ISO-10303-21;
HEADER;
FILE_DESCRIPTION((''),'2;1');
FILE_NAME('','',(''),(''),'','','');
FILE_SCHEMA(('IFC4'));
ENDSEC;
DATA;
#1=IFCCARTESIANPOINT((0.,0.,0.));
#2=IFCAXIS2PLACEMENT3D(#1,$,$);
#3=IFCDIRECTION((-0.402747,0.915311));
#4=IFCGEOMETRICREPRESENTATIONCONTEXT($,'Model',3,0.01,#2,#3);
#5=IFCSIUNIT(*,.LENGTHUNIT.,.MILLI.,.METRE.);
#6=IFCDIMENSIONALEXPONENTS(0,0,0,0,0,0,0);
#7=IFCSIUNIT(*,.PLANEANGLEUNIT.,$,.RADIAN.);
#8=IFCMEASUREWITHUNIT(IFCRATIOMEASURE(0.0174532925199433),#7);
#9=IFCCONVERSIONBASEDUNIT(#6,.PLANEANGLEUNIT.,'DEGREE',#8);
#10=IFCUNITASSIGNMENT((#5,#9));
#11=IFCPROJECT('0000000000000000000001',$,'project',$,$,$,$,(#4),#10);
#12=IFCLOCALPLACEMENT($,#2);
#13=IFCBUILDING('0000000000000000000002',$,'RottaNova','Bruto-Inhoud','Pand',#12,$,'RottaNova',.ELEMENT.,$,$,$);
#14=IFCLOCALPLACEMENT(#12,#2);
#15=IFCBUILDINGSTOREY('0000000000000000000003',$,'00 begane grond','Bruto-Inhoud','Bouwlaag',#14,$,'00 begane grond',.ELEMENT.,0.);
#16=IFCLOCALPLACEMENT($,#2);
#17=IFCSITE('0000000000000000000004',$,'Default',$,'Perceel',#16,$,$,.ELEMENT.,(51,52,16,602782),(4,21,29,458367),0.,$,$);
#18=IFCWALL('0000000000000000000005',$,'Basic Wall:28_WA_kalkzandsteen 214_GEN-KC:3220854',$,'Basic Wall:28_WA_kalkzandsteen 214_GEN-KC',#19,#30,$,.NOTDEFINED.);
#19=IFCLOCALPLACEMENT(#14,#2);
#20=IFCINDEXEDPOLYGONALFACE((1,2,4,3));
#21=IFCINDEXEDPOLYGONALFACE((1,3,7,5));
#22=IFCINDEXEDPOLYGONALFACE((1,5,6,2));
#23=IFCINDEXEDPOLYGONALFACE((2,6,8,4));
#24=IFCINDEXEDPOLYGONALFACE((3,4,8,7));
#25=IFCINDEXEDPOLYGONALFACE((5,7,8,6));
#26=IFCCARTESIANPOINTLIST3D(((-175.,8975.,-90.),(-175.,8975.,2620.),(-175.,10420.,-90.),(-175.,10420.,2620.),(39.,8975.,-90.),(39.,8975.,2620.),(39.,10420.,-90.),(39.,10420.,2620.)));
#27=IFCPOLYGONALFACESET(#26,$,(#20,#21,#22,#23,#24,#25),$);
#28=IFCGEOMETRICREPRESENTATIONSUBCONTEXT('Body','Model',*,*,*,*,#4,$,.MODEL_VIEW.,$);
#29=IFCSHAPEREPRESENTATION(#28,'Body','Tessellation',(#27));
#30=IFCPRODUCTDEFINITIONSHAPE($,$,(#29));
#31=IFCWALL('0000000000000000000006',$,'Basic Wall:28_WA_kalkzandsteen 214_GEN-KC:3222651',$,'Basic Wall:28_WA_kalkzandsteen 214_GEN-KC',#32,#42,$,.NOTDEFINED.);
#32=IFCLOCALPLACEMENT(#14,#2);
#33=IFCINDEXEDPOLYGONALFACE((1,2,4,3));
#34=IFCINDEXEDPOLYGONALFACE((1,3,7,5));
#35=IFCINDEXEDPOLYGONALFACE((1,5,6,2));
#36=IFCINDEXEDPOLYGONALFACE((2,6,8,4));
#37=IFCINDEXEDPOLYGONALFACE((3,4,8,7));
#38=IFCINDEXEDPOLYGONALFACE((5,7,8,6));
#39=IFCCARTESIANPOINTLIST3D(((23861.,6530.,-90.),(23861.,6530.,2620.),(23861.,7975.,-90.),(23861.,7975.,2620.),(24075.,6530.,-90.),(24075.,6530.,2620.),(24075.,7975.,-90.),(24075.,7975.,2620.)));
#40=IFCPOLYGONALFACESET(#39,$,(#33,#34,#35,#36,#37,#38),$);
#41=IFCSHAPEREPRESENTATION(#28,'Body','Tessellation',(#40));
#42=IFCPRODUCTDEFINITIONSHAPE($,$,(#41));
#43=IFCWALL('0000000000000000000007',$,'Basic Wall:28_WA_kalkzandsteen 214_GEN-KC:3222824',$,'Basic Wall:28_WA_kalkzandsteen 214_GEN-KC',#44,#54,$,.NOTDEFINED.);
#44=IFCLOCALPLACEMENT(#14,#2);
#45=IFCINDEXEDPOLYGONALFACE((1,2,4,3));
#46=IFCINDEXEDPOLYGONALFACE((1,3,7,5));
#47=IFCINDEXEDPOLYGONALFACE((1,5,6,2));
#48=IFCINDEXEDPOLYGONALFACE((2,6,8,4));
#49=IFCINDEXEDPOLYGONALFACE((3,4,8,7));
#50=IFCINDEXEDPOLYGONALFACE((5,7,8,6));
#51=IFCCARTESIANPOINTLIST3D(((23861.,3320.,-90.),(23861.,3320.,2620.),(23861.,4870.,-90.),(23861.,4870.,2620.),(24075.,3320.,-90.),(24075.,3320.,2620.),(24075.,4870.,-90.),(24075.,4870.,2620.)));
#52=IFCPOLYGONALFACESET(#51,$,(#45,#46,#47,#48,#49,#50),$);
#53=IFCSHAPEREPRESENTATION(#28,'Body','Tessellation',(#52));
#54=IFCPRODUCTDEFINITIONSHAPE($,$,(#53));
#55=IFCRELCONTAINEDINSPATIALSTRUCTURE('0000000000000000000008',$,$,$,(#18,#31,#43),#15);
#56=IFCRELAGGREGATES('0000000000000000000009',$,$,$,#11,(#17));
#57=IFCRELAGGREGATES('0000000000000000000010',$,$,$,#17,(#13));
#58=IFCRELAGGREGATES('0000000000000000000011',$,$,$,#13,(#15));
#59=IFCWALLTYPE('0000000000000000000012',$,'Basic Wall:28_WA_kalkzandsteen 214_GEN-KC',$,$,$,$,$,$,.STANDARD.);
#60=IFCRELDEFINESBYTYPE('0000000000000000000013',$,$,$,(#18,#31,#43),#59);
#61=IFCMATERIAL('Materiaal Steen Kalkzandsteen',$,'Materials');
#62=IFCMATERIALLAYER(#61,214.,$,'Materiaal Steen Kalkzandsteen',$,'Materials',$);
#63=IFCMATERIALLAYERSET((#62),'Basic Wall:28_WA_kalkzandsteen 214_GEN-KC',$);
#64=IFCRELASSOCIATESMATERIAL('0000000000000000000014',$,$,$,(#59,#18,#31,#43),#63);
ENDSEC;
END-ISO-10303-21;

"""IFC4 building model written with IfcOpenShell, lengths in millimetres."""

from ifc_helpers import new_model, entity, si_unit, converted_unit, direction, frame, frame_2d, origin, place, context, subcontext, project, spatial, rectangle, extrude, material, layer, layer_set, type_object, element, save


model = new_model("IFC4")

# Units and contexts
model_context = context("Model", 3, precision=0.01, world=origin(), true_north=direction((-0.402747, 0.915311)))
body_context = subcontext(model_context, "Body", "Model", "MODEL_VIEW")
ifc_project = project(units=[si_unit("LENGTHUNIT", "METRE", prefix="MILLI"), converted_unit("PLANEANGLEUNIT", "DEGREE", entity("IfcRatioMeasure", 0.0174532925199433), si_unit("PLANEANGLEUNIT", "RADIAN"), dimensions=[0, 0, 0, 0, 0, 0, 0])], contexts=[model_context])

# Site, building, storey
site_placement = place(None, origin())
site = spatial("IfcSite", under=ifc_project, at=site_placement, Name="Default", ObjectType="Perceel", CompositionType="ELEMENT", RefLatitude=(51, 52, 16, 602782), RefLongitude=(4, 21, 29, 458367), RefElevation=0.0)
building_placement = place(None, origin())
building = spatial("IfcBuilding", under=site, at=building_placement, Name="RottaNova", Description="Bruto-Inhoud", ObjectType="Pand", LongName="RottaNova", CompositionType="ELEMENT")
storey_placement = place(building_placement, origin())
storey = spatial("IfcBuildingStorey", under=building, at=storey_placement, Name="00 begane grond", Description="Bruto-Inhoud", ObjectType="Bouwlaag", LongName="00 begane grond", CompositionType="ELEMENT", Elevation=0.0)

# Walls
ifc_material_1 = material(Name="Materiaal Steen Kalkzandsteen", Category="Materials")
ifc_layer_1 = layer(ifc_material_1, 214.0, Name="Materiaal Steen Kalkzandsteen", Category="Materials")
ifc_layer_set_1 = layer_set([ifc_layer_1], Name="Basic Wall:28_WA_kalkzandsteen 214_GEN-KC")
wall_type = type_object("IfcWallType", Name="Basic Wall:28_WA_kalkzandsteen 214_GEN-KC", PredefinedType="STANDARD", material=ifc_layer_set_1)
wall_1_placement = place(storey_placement, frame((-68.0, 8975.0, -90.0), z_axis=(0.0, 0.0, 1.0), x_axis=(0.0, 1.0, 0.0)))
element("IfcWall", 1, at=wall_1_placement, inside=storey, type_object=wall_type, material=ifc_layer_set_1, Name="Basic Wall:28_WA_kalkzandsteen 214_GEN-KC:3220854", ObjectType="Basic Wall:28_WA_kalkzandsteen 214_GEN-KC", PredefinedType="NOTDEFINED", context=body_context, shape_type="SweptSolid", body=[
    extrude(rectangle(XDim=1445.0, YDim=214.0, at=frame_2d((722.5, 0.0), x_axis=(-1.0, 0.0))), origin(), (0.0, 0.0, 1.0), 2710.0),
])
wall_2_placement = place(storey_placement, frame((23968.0, 7975.0, -90.0), z_axis=(0.0, 0.0, 1.0), x_axis=(0.0, -1.0, 0.0)))
element("IfcWall", 2, at=wall_2_placement, inside=storey, type_object=wall_type, material=ifc_layer_set_1, Name="Basic Wall:28_WA_kalkzandsteen 214_GEN-KC:3222651", ObjectType="Basic Wall:28_WA_kalkzandsteen 214_GEN-KC", PredefinedType="NOTDEFINED", context=body_context, shape_type="SweptSolid", body=[
    extrude(rectangle(XDim=1445.0, YDim=214.0, at=frame_2d((722.5, 0.0), x_axis=(-1.0, 0.0))), origin(), (0.0, 0.0, 1.0), 2710.0),
])
wall_3_placement = place(storey_placement, frame((23968.0, 4870.0, -90.0), z_axis=(0.0, 0.0, 1.0), x_axis=(0.0, -1.0, 0.0)))
element("IfcWall", 3, at=wall_3_placement, inside=storey, type_object=wall_type, material=ifc_layer_set_1, Name="Basic Wall:28_WA_kalkzandsteen 214_GEN-KC:3222824", ObjectType="Basic Wall:28_WA_kalkzandsteen 214_GEN-KC", PredefinedType="NOTDEFINED", context=body_context, shape_type="SweptSolid", body=[
    extrude(rectangle(XDim=1550.0, YDim=214.0, at=frame_2d((775.0, 0.0), x_axis=(-1.0, 0.0))), origin(), (0.0, 0.0, 1.0), 2710.0),
])

save(model, "model.ifc")
